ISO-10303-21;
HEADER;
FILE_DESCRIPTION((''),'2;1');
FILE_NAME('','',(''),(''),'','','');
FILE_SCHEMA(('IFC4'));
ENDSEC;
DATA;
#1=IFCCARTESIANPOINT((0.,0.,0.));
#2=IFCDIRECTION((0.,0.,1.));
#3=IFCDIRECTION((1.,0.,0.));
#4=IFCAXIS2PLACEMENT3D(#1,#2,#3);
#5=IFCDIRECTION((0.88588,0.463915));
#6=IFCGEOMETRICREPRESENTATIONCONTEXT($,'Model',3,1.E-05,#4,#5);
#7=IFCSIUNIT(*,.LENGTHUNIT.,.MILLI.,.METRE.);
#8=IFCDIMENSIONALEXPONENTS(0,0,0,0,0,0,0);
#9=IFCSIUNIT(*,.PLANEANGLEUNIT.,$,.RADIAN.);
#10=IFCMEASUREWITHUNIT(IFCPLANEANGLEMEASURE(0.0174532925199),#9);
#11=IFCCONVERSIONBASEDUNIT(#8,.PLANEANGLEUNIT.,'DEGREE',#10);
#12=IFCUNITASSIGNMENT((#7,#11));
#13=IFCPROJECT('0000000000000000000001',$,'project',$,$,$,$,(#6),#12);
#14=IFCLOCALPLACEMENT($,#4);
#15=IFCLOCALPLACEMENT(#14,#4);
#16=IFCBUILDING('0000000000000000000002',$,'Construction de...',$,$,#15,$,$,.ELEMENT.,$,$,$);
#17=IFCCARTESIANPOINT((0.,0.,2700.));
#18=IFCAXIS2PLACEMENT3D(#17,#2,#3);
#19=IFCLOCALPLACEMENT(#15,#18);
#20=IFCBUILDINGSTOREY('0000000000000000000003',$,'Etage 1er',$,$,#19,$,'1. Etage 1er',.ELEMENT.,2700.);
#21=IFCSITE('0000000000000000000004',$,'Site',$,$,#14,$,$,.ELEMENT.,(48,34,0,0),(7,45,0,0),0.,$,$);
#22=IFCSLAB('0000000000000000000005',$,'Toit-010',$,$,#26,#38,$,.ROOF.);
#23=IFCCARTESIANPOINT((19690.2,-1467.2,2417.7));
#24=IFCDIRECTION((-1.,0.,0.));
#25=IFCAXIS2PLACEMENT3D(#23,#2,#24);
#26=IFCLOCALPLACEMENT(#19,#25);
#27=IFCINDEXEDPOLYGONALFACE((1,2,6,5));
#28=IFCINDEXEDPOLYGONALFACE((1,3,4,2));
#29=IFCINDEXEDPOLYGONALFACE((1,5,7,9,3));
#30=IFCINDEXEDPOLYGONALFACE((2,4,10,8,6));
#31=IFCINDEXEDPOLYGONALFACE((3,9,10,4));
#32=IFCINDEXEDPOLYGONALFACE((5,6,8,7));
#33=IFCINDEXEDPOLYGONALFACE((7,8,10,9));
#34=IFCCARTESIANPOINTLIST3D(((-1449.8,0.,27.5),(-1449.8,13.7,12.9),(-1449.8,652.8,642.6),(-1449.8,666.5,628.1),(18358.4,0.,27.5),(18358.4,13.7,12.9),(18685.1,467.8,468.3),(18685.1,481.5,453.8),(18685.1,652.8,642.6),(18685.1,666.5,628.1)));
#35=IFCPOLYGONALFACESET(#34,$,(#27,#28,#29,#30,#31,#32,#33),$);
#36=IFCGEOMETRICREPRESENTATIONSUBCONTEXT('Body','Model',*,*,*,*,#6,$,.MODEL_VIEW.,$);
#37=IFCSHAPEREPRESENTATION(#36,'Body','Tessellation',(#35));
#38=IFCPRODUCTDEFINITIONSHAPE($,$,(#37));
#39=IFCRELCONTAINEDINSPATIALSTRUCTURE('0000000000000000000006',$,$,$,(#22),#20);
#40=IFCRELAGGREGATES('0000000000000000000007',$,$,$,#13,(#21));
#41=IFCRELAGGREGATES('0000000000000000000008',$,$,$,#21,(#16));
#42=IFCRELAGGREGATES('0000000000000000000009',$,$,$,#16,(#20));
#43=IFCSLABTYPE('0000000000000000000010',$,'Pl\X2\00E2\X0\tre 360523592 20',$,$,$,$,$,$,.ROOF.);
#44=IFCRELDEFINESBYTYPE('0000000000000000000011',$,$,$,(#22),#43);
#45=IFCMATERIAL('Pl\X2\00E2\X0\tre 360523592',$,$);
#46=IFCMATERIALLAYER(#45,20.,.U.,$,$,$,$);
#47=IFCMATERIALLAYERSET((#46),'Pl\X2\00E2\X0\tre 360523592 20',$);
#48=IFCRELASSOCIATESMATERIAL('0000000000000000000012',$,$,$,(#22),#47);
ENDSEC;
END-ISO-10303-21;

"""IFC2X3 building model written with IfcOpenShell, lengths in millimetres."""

from ifc_helpers import new_model, entity, si_unit, converted_unit, direction, frame, origin_with_axes, place, context, subcontext, project, spatial, polyline, outline, extrude, material, layer, layer_set, layer_usage, type_object, element, save


model = new_model("IFC2X3")

# Units and contexts
model_context = context("Model", 3, precision=1e-05, world=origin_with_axes(), true_north=direction((0.88588, 0.463915)))
body_context = subcontext(model_context, "Body", "Model", "MODEL_VIEW")
ifc_project = project(units=[si_unit("LENGTHUNIT", "METRE", prefix="MILLI"), converted_unit("PLANEANGLEUNIT", "DEGREE", entity("IfcPlaneAngleMeasure", 0.0174532925199), si_unit("PLANEANGLEUNIT", "RADIAN"), dimensions=[0, 0, 0, 0, 0, 0, 0])], contexts=[model_context])

# Site, building, storey
site_placement = place(None, origin_with_axes())
site = spatial("IfcSite", under=ifc_project, at=site_placement, Name="Site", CompositionType="ELEMENT", RefLatitude=(48, 34, 0, 0), RefLongitude=(7, 45, 0, 0), RefElevation=0.0)
building_placement = place(site_placement, origin_with_axes())
building = spatial("IfcBuilding", under=site, at=building_placement, Name="Construction de...", CompositionType="ELEMENT")
storey_placement = place(building_placement, frame((0.0, 0.0, 2700.0), z_axis=(0.0, 0.0, 1.0), x_axis=(1.0, 0.0, 0.0)))
storey = spatial("IfcBuildingStorey", under=building, at=storey_placement, Name="Etage 1er", LongName="1. Etage 1er", CompositionType="ELEMENT", Elevation=2700.0)

# Slab
ifc_material_1 = material(Name="Plâtre 360523592")
ifc_layer_1 = layer(ifc_material_1, 20.0, ventilated="UNKNOWN")
ifc_layer_set_1 = layer_set([ifc_layer_1], Name="Plâtre 360523592 20")
ifc_layer_usage_1 = layer_usage(ifc_layer_set_1, "AXIS3", "NEGATIVE", 20.0)
slab_type = type_object("IfcSlabType", Name="Plâtre 360523592 20", PredefinedType="ROOF")
slab_placement = place(storey_placement, frame((19690.2, -1467.2, 2417.7), z_axis=(0.0, 0.0, 1.0), x_axis=(-1.0, 0.0, 0.0)))
element("IfcSlab", 1, at=slab_placement, inside=storey, type_object=slab_type, material=ifc_layer_usage_1, Name="Toit-010", PredefinedType="ROOF", context=body_context, shape_type="SweptSolid", body=[
    extrude(outline(polyline([(-1449.8, 18.8), (18358.4, 18.8), (18685.1, 661.6), (18685.1, 915.8), (-1449.8, 915.8), (-1449.8, 18.8)])), frame((0.0, 0.0, 0.0), z_axis=(0.0, -0.685818, 0.727773), x_axis=(1.0, 0.0, 0.0)), (0.0, 0.0, 1.0), 20.0),
])

save(model, "model.ifc")
